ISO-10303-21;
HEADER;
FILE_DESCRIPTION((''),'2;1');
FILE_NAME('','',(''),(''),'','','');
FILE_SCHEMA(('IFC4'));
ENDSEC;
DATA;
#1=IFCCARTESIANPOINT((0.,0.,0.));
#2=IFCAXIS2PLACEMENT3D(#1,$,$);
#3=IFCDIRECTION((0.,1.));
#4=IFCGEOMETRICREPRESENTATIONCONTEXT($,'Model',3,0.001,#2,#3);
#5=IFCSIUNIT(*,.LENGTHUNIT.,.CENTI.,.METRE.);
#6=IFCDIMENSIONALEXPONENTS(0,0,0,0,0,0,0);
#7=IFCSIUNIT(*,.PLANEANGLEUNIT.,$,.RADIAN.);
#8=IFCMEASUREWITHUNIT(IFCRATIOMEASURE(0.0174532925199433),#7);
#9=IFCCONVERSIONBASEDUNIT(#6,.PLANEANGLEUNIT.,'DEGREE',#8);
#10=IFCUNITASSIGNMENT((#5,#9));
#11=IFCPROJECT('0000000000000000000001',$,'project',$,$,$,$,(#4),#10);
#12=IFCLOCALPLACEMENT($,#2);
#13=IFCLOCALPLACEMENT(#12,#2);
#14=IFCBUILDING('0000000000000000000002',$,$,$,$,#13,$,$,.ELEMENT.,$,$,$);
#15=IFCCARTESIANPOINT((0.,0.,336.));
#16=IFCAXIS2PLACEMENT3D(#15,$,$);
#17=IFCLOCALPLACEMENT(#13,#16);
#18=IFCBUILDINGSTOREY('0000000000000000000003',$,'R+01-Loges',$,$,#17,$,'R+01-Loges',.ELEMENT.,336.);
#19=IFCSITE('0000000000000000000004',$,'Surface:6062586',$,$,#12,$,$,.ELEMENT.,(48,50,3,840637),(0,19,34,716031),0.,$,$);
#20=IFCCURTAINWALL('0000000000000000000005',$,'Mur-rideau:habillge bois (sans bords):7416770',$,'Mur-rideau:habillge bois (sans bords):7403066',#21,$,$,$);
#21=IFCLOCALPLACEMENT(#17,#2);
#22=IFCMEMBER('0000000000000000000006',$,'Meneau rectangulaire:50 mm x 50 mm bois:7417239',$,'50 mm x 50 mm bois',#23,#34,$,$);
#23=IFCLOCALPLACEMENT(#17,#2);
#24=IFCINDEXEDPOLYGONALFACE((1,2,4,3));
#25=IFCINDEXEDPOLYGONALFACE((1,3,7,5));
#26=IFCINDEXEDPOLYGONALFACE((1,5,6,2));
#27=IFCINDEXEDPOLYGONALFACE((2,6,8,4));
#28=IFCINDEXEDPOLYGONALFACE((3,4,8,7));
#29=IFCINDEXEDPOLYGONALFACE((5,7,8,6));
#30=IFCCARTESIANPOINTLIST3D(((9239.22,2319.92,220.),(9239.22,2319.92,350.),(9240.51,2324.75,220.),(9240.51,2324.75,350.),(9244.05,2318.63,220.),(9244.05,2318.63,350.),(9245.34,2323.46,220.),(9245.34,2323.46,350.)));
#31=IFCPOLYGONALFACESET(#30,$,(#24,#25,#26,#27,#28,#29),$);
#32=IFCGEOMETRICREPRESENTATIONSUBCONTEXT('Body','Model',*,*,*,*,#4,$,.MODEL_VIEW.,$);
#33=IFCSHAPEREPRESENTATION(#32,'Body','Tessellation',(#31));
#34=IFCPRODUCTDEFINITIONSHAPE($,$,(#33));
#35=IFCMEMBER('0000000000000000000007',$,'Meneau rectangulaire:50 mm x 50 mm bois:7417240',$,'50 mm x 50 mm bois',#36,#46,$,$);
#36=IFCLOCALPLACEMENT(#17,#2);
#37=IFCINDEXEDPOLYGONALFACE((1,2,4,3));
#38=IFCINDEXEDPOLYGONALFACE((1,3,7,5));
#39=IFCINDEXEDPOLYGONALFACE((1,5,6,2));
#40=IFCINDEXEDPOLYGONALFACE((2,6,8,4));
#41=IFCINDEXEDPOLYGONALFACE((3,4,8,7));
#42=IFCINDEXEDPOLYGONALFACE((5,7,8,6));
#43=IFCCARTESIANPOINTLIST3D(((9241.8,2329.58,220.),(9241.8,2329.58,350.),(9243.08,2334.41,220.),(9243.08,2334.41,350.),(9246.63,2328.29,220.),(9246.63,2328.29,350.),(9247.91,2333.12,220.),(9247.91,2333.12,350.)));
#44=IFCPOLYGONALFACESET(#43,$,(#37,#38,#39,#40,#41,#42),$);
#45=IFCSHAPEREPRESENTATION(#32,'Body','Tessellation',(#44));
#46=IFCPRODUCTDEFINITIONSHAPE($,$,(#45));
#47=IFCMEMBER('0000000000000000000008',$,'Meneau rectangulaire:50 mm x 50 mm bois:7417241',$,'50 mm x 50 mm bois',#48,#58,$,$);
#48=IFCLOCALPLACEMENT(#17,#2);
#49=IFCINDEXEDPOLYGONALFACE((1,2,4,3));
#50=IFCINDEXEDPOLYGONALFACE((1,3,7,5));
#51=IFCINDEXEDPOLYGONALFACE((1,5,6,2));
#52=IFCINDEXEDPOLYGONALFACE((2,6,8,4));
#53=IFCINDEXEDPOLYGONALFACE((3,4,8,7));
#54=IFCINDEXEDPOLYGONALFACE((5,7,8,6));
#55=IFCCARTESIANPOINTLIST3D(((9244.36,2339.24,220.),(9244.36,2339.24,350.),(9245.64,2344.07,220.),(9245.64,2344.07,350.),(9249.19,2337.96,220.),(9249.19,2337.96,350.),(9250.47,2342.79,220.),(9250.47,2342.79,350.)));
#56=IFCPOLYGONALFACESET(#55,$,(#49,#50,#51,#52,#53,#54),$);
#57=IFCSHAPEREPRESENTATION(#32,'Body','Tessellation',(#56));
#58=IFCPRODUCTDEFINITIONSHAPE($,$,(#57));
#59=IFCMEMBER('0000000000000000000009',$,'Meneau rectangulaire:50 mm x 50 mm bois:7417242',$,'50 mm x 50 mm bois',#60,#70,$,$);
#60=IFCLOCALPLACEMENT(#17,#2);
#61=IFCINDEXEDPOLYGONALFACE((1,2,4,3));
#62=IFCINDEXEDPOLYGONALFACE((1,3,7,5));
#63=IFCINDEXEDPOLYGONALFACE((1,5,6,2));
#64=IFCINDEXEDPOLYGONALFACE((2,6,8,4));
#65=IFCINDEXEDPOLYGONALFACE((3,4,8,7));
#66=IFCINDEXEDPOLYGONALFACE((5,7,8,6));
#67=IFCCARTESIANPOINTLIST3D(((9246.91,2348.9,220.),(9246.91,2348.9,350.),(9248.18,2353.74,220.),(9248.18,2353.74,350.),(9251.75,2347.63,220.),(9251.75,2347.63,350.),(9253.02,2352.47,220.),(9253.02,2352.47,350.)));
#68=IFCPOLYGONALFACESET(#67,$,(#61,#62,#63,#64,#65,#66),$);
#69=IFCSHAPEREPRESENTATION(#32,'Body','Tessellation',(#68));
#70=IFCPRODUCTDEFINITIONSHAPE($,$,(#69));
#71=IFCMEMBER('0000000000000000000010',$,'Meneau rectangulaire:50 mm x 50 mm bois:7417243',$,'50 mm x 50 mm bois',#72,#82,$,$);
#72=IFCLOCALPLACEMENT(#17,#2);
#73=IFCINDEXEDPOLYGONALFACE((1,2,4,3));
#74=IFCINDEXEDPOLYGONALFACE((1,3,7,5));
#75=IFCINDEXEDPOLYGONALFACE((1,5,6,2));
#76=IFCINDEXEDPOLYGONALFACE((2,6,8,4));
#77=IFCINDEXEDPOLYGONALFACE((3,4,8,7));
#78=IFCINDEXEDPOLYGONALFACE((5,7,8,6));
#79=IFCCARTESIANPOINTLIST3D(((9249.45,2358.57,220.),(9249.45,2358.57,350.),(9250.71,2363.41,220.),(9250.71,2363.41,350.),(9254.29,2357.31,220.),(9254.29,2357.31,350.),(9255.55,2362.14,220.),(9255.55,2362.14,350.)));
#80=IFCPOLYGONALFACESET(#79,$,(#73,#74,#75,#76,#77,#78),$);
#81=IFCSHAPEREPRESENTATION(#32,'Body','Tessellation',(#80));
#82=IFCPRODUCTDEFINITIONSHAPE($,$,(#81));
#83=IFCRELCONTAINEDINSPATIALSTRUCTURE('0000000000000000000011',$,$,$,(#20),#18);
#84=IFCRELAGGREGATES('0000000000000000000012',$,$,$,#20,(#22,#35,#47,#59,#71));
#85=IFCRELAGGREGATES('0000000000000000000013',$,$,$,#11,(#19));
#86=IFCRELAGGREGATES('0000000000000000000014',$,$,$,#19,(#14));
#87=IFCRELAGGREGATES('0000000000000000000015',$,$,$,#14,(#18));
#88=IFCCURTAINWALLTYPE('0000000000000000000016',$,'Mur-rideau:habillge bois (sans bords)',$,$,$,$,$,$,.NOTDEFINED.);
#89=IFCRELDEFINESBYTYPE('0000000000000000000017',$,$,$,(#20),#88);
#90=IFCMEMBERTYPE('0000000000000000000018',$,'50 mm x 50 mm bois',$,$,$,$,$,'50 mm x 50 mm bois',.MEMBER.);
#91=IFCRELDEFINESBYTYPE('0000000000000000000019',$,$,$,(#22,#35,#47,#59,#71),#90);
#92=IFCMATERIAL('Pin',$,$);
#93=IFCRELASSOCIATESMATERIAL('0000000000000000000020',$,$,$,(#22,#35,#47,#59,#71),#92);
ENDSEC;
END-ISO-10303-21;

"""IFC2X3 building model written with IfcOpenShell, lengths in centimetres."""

from ifc_helpers import new_model, entity, si_unit, converted_unit, direction, frame, origin, origin_2d_with_axis, place, context, subcontext, project, spatial, rectangle, extrude, source, transform, mapped, material, type_object, type_shapes, element, aggregate, save


model = new_model("IFC2X3")

# Units and contexts
model_context = context("Model", 3, precision=0.001, world=origin(), true_north=direction((0.0, 1.0)))
body_context = subcontext(model_context, "Body", "Model", "MODEL_VIEW")
ifc_project = project(units=[si_unit("LENGTHUNIT", "METRE", prefix="CENTI"), converted_unit("PLANEANGLEUNIT", "DEGREE", entity("IfcRatioMeasure", 0.0174532925199433), si_unit("PLANEANGLEUNIT", "RADIAN"), dimensions=[0, 0, 0, 0, 0, 0, 0])], contexts=[model_context])

# Site, building, storey
site_placement = place(None, origin())
site = spatial("IfcSite", under=ifc_project, at=site_placement, Name="Surface:6062586", CompositionType="ELEMENT", RefLatitude=(48, 50, 3, 840637), RefLongitude=(0, 19, 34, 716031), RefElevation=0.0)
building_placement = place(site_placement, origin())
building = spatial("IfcBuilding", under=site, at=building_placement, CompositionType="ELEMENT")
storey_placement = place(building_placement, frame((0.0, 0.0, 336.0)))
storey = spatial("IfcBuildingStorey", under=building, at=storey_placement, Name="R+01-Loges", LongName="R+01-Loges", CompositionType="ELEMENT", Elevation=336.0)

# Curtain wall, members
curtain_wall_type = type_object("IfcCurtainWallType", Name="Mur-rideau:habillge bois (sans bords)", PredefinedType="NOTDEFINED")
curtain_wall_placement = place(storey_placement, frame((0.0, 0.0, -336.0)))
curtain_wall = element("IfcCurtainWall", 1, at=curtain_wall_placement, inside=storey, type_object=curtain_wall_type, Name="Mur-rideau:habillge bois (sans bords):7416770", ObjectType="Mur-rideau:habillge bois (sans bords):7403066")
ifc_material_1 = material(Name="Pin")
member_type = type_object("IfcMemberType", Name="50 mm x 50 mm bois", ElementType="50 mm x 50 mm bois", PredefinedType="MEMBER")
shared_shape = source(origin(), body_context, "Body", "SweptSolid", [
    extrude(rectangle(XDim=5.0, YDim=5.0, at=origin_2d_with_axis()), frame((0.0, 0.0, -130.0), z_axis=(0.0, 0.0, 1.0), x_axis=(0.0, -1.0, 0.0)), (0.0, 0.0, 1.0), 130.0),
])
type_shapes(member_type, [shared_shape])
member_1_placement = place(storey_placement, frame((9242.28, 2321.69, 220.0), z_axis=(0.0, 0.0, -1.0), x_axis=(0.257938, 0.966161, 0.0)))
member_1 = element("IfcMember", 2, at=member_1_placement, type_object=member_type, material=ifc_material_1, Name="Meneau rectangulaire:50 mm x 50 mm bois:7417239", ObjectType="50 mm x 50 mm bois", context=body_context, shape_type="MappedRepresentation", body=[
    mapped(shared_shape, transform((0.0, 0.0, 0.0), scale=1.0)),
])
member_2_placement = place(storey_placement, frame((9244.85, 2331.35, 220.0), z_axis=(0.0, 0.0, -1.0), x_axis=(0.256717, 0.966487, 0.0)))
member_2 = element("IfcMember", 3, at=member_2_placement, type_object=member_type, material=ifc_material_1, Name="Meneau rectangulaire:50 mm x 50 mm bois:7417240", ObjectType="50 mm x 50 mm bois", context=body_context, shape_type="MappedRepresentation", body=[
    mapped(shared_shape, transform((0.0, 0.0, 0.0), scale=1.0)),
])
member_3_placement = place(storey_placement, frame((9247.42, 2341.02, 220.0), z_axis=(0.0, 0.0, -1.0), x_axis=(0.255496, 0.96681, 0.0)))
member_3 = element("IfcMember", 4, at=member_3_placement, type_object=member_type, material=ifc_material_1, Name="Meneau rectangulaire:50 mm x 50 mm bois:7417241", ObjectType="50 mm x 50 mm bois", context=body_context, shape_type="MappedRepresentation", body=[
    mapped(shared_shape, transform((0.0, 0.0, 0.0), scale=1.0)),
])
member_4_placement = place(storey_placement, frame((9249.96, 2350.69, 220.0), z_axis=(0.0, 0.0, -1.0), x_axis=(0.254274, 0.967132, 0.0)))
member_4 = element("IfcMember", 5, at=member_4_placement, type_object=member_type, material=ifc_material_1, Name="Meneau rectangulaire:50 mm x 50 mm bois:7417242", ObjectType="50 mm x 50 mm bois", context=body_context, shape_type="MappedRepresentation", body=[
    mapped(shared_shape, transform((0.0, 0.0, 0.0), scale=1.0)),
])
member_5_placement = place(storey_placement, frame((9252.5, 2360.36, 220.0), z_axis=(0.0, 0.0, -1.0), x_axis=(0.253052, 0.967453, 0.0)))
member_5 = element("IfcMember", 6, at=member_5_placement, type_object=member_type, material=ifc_material_1, Name="Meneau rectangulaire:50 mm x 50 mm bois:7417243", ObjectType="50 mm x 50 mm bois", context=body_context, shape_type="MappedRepresentation", body=[
    mapped(shared_shape, transform((0.0, 0.0, 0.0), scale=1.0)),
])
aggregate(curtain_wall, [member_1, member_2, member_3, member_4, member_5])

save(model, "model.ifc")
